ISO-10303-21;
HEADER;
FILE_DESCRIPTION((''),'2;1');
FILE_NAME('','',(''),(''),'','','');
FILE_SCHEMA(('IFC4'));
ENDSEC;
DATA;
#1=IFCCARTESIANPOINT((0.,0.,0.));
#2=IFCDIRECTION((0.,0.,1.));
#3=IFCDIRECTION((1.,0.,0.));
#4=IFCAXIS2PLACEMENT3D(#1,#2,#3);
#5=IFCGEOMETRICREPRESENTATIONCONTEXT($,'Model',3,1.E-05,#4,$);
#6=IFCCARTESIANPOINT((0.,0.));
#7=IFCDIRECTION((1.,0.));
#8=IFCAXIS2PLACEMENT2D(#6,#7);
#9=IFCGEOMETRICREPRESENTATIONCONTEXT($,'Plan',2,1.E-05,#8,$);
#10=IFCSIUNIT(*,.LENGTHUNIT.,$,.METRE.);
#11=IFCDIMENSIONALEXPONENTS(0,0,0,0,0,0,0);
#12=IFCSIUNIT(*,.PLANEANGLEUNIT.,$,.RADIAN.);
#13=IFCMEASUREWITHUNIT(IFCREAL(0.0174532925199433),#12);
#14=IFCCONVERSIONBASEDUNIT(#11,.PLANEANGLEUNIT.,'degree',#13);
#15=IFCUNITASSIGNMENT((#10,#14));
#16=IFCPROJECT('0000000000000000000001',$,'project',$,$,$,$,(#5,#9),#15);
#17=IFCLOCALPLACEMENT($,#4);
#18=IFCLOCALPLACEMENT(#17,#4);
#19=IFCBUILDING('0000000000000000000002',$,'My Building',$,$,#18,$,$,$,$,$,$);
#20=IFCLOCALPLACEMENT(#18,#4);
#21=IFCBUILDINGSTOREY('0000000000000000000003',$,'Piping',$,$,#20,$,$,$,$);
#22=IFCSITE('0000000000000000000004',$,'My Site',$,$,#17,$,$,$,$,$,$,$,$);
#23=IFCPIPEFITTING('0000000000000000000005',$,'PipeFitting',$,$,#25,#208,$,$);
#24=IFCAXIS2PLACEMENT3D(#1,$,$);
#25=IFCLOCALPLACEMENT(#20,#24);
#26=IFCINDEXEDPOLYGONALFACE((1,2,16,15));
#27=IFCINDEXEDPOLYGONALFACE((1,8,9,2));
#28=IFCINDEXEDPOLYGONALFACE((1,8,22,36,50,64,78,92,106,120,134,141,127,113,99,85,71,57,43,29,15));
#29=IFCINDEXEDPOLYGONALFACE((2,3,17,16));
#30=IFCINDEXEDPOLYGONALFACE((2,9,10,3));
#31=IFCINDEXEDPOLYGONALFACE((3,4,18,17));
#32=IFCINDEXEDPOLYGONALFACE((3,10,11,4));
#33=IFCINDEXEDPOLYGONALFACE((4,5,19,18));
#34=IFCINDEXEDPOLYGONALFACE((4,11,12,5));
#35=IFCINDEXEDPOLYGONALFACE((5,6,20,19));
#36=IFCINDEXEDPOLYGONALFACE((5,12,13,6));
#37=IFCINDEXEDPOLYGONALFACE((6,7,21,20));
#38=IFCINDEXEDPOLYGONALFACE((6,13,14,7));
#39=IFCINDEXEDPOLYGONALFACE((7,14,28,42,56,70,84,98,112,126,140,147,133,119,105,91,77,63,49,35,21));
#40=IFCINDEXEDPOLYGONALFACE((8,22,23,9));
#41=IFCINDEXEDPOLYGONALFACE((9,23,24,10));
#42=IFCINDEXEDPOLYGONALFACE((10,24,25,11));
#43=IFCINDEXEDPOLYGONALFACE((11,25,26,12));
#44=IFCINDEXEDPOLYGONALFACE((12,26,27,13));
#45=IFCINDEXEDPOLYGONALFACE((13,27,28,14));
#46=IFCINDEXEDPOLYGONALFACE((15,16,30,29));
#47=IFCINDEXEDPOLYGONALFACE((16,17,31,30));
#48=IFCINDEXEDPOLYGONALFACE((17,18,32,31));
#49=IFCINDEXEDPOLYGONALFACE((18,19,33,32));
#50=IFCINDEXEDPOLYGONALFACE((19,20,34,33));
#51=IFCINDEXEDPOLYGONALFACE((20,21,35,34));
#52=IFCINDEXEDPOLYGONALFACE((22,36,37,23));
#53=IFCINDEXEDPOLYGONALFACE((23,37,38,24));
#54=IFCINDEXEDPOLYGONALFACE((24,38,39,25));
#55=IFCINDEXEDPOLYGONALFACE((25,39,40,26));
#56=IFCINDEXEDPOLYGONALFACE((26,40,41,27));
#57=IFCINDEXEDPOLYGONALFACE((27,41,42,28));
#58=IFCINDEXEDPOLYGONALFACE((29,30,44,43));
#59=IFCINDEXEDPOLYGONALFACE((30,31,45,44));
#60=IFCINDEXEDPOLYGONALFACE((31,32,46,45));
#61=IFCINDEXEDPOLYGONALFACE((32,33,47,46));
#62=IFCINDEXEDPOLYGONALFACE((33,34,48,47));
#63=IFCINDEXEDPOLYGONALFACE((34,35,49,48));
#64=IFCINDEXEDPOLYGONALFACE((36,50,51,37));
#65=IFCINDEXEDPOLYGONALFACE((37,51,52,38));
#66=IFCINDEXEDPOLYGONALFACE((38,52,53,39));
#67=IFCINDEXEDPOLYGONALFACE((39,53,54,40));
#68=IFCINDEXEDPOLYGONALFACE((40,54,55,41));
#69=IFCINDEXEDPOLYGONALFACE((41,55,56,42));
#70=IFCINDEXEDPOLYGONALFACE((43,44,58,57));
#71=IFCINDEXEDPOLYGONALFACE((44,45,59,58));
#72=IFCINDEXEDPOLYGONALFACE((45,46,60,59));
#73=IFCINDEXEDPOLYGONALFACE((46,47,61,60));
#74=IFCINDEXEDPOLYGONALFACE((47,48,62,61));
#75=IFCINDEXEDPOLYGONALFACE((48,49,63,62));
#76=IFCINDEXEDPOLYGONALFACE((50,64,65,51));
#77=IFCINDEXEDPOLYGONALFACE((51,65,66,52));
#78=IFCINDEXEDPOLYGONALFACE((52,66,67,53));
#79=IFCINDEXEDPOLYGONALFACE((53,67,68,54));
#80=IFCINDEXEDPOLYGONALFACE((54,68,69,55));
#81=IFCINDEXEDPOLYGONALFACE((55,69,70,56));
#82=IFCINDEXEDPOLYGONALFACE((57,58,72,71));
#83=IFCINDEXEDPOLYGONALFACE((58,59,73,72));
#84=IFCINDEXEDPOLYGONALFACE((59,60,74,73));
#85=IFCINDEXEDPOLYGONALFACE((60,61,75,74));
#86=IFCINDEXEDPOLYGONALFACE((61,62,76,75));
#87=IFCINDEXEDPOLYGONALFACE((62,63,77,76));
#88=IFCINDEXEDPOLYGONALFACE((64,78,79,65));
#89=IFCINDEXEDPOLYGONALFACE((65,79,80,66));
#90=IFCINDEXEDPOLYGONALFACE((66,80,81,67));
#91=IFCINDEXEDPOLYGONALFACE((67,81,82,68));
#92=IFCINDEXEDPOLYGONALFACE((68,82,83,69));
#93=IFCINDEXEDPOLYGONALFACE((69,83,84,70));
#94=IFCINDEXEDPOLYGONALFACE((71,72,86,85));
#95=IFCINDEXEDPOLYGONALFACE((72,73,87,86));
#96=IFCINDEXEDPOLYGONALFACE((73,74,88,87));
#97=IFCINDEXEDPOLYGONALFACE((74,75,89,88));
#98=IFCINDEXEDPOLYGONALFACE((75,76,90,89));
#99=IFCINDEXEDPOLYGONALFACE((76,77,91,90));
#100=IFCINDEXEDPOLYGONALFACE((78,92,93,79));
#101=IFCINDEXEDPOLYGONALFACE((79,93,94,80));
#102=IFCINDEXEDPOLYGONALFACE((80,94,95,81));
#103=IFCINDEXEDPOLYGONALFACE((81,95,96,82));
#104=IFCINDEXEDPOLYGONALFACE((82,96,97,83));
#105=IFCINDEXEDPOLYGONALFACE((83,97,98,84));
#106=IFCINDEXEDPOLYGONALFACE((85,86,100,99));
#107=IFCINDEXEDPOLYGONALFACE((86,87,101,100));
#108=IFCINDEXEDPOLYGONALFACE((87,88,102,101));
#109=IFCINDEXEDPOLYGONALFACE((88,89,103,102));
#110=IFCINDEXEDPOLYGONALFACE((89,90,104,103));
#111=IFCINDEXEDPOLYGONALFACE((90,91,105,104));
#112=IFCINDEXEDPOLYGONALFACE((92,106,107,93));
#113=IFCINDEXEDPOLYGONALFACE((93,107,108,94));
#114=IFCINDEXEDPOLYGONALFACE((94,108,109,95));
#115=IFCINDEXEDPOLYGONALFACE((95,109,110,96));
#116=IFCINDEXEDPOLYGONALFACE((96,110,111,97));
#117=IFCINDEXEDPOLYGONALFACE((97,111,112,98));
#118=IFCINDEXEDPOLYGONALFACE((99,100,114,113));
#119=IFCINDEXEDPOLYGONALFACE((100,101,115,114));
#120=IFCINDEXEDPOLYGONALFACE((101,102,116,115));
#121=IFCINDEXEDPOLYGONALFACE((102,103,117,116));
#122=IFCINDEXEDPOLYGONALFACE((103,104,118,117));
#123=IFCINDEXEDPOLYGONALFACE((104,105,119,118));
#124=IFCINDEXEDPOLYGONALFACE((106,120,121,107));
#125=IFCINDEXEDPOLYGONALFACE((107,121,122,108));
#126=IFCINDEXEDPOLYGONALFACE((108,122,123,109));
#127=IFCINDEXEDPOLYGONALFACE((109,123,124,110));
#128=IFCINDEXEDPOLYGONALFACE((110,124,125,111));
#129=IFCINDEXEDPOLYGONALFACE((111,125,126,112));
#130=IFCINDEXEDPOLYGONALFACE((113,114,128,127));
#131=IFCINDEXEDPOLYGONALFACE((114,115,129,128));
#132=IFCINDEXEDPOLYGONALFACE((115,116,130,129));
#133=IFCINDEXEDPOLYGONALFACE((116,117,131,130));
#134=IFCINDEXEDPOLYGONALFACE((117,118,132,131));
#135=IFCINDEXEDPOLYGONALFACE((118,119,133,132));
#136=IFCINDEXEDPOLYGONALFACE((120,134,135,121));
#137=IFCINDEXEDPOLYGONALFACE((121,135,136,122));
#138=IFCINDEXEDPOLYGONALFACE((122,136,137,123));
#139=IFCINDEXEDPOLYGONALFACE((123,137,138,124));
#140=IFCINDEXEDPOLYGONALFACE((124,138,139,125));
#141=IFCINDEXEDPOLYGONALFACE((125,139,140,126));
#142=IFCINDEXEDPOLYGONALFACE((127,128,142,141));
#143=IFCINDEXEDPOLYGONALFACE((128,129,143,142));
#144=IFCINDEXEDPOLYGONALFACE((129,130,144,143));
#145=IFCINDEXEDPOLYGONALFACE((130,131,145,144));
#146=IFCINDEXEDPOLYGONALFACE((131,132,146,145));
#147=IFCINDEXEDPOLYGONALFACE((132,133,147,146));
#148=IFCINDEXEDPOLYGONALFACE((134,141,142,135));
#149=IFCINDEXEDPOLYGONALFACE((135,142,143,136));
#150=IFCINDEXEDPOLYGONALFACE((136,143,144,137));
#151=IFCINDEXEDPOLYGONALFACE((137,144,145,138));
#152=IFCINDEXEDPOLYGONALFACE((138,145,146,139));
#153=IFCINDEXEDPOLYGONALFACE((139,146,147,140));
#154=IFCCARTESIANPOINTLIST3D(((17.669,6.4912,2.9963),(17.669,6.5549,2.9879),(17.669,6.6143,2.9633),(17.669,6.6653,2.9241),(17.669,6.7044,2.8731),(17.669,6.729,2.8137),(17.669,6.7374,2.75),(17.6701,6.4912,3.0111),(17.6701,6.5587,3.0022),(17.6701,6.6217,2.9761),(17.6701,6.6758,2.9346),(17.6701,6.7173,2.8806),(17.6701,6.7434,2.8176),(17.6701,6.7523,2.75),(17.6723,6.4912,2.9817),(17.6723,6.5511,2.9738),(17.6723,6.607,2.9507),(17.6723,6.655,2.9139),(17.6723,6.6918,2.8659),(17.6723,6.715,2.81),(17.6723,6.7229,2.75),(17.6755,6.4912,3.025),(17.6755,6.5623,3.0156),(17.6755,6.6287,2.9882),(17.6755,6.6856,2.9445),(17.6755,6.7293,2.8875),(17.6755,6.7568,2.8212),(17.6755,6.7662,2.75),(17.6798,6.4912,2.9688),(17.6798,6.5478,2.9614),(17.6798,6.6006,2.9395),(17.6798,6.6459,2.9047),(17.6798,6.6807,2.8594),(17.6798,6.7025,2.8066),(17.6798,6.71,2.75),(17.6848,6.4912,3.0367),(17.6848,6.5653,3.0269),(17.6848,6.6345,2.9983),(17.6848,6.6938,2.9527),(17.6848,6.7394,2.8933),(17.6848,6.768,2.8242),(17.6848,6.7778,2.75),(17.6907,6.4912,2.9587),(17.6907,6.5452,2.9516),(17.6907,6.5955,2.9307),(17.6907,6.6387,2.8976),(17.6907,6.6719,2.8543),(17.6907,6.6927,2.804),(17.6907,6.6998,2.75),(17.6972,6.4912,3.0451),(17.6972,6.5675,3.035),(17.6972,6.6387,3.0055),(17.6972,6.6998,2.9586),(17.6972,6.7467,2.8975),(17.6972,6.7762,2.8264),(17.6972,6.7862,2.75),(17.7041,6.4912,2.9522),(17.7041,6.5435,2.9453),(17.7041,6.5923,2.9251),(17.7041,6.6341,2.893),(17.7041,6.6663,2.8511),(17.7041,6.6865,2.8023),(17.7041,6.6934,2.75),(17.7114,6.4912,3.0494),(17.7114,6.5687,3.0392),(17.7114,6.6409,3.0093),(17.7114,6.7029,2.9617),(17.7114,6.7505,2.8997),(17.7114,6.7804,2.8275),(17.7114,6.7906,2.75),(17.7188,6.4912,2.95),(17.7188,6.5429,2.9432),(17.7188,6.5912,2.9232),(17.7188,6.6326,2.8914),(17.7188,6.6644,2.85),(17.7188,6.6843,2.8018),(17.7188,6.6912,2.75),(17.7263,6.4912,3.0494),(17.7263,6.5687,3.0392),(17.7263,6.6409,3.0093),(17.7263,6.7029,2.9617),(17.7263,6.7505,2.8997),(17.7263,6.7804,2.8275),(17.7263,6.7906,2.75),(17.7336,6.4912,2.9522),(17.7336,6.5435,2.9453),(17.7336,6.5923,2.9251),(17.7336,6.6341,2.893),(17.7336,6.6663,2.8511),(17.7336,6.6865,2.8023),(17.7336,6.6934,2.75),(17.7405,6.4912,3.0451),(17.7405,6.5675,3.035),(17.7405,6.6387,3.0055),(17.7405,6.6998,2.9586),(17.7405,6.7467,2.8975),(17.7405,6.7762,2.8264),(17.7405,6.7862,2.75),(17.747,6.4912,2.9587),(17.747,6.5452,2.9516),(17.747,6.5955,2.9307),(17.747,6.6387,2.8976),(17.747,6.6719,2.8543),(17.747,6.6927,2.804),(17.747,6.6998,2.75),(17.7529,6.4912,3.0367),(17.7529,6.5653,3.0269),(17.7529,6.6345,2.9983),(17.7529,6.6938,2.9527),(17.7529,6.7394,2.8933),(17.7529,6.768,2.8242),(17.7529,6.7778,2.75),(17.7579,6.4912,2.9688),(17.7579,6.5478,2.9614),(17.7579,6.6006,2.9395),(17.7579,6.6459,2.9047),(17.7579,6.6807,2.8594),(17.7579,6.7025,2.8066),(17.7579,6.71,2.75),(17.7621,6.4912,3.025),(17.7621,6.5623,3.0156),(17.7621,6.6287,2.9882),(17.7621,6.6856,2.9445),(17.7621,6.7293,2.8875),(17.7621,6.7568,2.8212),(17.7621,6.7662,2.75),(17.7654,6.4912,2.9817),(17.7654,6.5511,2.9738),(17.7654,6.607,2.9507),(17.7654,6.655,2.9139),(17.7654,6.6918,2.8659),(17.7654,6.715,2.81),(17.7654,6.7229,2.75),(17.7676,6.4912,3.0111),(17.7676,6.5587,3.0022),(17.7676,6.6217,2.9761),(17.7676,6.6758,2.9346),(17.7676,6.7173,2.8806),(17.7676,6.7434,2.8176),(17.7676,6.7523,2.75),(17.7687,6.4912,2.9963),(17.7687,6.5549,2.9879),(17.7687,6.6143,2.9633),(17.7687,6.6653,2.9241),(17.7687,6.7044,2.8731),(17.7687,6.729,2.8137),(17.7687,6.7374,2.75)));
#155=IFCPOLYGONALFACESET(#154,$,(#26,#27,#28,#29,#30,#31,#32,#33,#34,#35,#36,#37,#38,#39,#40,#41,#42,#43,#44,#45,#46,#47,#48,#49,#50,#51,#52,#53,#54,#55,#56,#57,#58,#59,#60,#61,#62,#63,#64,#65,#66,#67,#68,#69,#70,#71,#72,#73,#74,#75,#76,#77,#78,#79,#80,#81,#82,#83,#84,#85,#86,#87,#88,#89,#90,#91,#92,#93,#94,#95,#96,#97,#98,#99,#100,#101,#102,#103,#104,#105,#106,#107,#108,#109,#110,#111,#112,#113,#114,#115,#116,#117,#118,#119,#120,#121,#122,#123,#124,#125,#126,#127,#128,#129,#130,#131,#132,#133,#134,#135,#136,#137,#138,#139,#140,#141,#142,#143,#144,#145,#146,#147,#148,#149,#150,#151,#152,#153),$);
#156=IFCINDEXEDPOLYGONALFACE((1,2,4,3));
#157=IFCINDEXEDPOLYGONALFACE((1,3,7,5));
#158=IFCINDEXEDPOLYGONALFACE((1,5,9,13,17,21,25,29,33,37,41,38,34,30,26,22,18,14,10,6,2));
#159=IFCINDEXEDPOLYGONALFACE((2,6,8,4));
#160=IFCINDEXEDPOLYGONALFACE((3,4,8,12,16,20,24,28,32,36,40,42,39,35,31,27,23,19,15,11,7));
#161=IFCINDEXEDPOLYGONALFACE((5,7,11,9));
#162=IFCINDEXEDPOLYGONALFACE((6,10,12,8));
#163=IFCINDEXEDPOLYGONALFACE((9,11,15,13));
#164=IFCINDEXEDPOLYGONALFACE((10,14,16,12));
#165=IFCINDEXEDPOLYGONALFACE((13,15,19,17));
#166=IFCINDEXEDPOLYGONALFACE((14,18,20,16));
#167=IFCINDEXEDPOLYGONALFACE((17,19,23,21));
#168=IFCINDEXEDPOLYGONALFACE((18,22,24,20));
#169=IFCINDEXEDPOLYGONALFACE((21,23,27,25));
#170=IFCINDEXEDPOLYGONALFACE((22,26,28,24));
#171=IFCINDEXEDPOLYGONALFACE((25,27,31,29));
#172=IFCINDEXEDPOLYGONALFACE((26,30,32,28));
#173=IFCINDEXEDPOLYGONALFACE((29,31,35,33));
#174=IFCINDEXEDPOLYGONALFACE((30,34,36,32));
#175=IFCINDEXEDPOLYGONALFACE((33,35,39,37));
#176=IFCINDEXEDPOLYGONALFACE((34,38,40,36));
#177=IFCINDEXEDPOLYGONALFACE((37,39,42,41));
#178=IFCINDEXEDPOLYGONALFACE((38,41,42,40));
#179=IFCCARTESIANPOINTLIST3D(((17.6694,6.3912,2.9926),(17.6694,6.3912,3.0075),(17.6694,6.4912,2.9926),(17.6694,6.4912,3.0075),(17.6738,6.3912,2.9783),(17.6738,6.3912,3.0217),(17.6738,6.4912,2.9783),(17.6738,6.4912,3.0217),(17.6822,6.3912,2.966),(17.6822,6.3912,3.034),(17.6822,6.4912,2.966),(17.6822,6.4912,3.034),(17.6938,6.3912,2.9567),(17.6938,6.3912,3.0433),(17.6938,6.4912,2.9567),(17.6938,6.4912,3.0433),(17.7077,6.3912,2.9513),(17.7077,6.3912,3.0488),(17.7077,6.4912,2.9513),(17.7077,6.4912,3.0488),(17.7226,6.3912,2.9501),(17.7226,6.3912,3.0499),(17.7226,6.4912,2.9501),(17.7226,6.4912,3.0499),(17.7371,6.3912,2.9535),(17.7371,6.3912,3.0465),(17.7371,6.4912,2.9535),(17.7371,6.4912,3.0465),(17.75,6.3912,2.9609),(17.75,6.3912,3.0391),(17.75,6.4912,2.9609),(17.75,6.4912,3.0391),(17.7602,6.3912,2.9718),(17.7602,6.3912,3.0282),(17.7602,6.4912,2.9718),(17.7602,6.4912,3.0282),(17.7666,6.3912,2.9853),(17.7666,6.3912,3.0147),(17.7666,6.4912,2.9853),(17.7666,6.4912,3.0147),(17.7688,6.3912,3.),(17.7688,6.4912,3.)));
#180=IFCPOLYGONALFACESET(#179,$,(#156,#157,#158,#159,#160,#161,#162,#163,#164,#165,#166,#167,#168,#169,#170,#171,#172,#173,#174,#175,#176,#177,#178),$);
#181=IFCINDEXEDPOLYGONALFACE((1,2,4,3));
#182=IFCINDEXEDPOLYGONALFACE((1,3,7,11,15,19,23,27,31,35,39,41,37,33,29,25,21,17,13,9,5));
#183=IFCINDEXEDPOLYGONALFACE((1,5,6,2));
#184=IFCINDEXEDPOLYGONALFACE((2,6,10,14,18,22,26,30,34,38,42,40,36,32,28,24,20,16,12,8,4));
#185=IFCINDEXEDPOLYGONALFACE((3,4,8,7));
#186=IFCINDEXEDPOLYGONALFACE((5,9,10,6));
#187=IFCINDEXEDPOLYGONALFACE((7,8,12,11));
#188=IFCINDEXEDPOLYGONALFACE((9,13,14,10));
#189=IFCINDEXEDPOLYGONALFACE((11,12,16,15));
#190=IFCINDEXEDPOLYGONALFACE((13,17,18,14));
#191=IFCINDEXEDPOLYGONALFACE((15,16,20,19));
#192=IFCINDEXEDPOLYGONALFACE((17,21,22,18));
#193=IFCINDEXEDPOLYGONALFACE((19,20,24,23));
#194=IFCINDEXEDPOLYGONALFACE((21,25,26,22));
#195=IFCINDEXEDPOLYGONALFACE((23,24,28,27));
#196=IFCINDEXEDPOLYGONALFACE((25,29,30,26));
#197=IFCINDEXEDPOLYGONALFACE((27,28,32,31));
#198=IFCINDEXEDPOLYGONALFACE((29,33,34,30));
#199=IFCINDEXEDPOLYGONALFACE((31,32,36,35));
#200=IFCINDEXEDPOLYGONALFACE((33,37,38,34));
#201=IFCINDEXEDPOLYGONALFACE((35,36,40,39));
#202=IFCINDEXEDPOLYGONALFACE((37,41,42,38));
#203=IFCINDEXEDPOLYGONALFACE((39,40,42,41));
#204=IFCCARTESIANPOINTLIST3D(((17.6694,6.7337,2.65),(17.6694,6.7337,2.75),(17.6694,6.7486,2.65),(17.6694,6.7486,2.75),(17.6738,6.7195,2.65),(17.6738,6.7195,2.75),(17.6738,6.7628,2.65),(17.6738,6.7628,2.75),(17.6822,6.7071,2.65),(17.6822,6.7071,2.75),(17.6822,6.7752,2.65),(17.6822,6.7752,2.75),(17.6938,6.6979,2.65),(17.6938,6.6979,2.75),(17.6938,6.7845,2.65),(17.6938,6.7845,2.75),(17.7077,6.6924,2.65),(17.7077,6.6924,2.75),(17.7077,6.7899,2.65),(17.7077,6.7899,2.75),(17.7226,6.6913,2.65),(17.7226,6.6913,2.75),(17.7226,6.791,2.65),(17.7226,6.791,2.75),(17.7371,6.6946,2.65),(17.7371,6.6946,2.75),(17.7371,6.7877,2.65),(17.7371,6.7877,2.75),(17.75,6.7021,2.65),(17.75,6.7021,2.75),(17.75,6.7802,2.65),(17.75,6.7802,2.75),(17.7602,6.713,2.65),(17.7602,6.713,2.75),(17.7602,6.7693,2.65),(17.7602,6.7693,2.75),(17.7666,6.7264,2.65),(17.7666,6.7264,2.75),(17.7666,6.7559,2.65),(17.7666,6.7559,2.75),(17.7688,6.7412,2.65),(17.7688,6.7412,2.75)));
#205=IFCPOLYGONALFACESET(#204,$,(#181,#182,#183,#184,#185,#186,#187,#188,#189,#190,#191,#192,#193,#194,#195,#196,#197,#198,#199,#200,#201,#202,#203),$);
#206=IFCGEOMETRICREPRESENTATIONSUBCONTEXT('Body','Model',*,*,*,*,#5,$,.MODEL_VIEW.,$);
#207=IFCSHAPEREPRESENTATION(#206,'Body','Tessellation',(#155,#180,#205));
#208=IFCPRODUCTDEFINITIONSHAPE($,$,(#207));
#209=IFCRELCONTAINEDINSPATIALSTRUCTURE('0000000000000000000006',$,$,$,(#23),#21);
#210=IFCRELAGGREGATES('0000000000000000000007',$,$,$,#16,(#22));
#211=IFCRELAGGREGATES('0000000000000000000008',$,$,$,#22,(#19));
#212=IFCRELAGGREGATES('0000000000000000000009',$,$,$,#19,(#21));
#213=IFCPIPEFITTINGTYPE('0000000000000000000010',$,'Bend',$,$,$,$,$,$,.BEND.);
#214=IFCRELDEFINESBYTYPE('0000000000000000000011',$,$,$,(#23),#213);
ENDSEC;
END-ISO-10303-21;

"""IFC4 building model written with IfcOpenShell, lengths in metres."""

from ifc_helpers import new_model, entity, si_unit, converted_unit, frame, origin_with_axes, origin_2d_with_axis, place, context, subcontext, project, spatial, circle, extrude, source, transform, mapped, type_object, type_shapes, element, save


model = new_model("IFC4")

# Units and contexts
model_context = context("Model", 3, precision=1e-05, world=origin_with_axes())
plan_context = context("Plan", 2, precision=1e-05, world=origin_2d_with_axis())
body_context = subcontext(model_context, "Body", "Model", "MODEL_VIEW")
ifc_project = project(units=[si_unit("LENGTHUNIT", "METRE"), converted_unit("PLANEANGLEUNIT", "degree", entity("IfcReal", 0.0174532925199433), si_unit("PLANEANGLEUNIT", "RADIAN"), dimensions=[0, 0, 0, 0, 0, 0, 0])], contexts=[model_context, plan_context])

# Site, building, storey
site_placement = place(None, origin_with_axes())
site = spatial("IfcSite", under=ifc_project, at=site_placement, Name="My Site")
building_placement = place(site_placement, origin_with_axes())
building = spatial("IfcBuilding", under=site, at=building_placement, Name="My Building")
storey_placement = place(building_placement, origin_with_axes())
storey = spatial("IfcBuildingStorey", under=building, at=storey_placement, Name="Piping")

# Pipe fitting
pipe_fitting_type = type_object("IfcPipeFittingType", Name="Bend", PredefinedType="BEND")
shared_shape = source(origin_with_axes(), body_context, "Body", "SolidModel", [
    entity("IfcSweptDiskSolid", entity("IfcIndexedPolyCurve", entity("IfcCartesianPointList3D", [[0.0, 0.0, -0.1], [0.0, -0.0732, -0.2768], [0.0, -0.25, -0.35]]), [entity("IfcArcIndex", [1, 2, 3])]), 0.05),
    extrude(circle(Radius=0.05), origin_with_axes(), (0.0, 0.0, -1.0), 0.1),
    extrude(circle(Radius=0.05), frame((0.0, -0.25, -0.35), z_axis=(0.0, -1.0, 0.0), x_axis=(1.0, 0.0, 0.0)), (0.0, 0.0, 1.0), 0.1),
])
type_shapes(pipe_fitting_type, [shared_shape])
for number, where, z_axis, x_axis, name in (
    (1, (17.7188, 6.3912, 3.0), (0.0, -1.0, 0.0), (1.0, 0.0, 0.0), "PipeFitting"),
):
    element("IfcPipeFitting", number, at=place(storey_placement, frame(where, z_axis=z_axis, x_axis=x_axis)), inside=storey, type_object=pipe_fitting_type, Name=name, context=body_context, shape_type="MappedRepresentation", body=[
        mapped(shared_shape, transform((0.0, 0.0, 0.0), x_axis=(1.0, 0.0, 0.0), y_axis=(0.0, 1.0, 0.0), z_axis=(0.0, 0.0, 1.0), scale=1.0)),
    ])

save(model, "model.ifc")
